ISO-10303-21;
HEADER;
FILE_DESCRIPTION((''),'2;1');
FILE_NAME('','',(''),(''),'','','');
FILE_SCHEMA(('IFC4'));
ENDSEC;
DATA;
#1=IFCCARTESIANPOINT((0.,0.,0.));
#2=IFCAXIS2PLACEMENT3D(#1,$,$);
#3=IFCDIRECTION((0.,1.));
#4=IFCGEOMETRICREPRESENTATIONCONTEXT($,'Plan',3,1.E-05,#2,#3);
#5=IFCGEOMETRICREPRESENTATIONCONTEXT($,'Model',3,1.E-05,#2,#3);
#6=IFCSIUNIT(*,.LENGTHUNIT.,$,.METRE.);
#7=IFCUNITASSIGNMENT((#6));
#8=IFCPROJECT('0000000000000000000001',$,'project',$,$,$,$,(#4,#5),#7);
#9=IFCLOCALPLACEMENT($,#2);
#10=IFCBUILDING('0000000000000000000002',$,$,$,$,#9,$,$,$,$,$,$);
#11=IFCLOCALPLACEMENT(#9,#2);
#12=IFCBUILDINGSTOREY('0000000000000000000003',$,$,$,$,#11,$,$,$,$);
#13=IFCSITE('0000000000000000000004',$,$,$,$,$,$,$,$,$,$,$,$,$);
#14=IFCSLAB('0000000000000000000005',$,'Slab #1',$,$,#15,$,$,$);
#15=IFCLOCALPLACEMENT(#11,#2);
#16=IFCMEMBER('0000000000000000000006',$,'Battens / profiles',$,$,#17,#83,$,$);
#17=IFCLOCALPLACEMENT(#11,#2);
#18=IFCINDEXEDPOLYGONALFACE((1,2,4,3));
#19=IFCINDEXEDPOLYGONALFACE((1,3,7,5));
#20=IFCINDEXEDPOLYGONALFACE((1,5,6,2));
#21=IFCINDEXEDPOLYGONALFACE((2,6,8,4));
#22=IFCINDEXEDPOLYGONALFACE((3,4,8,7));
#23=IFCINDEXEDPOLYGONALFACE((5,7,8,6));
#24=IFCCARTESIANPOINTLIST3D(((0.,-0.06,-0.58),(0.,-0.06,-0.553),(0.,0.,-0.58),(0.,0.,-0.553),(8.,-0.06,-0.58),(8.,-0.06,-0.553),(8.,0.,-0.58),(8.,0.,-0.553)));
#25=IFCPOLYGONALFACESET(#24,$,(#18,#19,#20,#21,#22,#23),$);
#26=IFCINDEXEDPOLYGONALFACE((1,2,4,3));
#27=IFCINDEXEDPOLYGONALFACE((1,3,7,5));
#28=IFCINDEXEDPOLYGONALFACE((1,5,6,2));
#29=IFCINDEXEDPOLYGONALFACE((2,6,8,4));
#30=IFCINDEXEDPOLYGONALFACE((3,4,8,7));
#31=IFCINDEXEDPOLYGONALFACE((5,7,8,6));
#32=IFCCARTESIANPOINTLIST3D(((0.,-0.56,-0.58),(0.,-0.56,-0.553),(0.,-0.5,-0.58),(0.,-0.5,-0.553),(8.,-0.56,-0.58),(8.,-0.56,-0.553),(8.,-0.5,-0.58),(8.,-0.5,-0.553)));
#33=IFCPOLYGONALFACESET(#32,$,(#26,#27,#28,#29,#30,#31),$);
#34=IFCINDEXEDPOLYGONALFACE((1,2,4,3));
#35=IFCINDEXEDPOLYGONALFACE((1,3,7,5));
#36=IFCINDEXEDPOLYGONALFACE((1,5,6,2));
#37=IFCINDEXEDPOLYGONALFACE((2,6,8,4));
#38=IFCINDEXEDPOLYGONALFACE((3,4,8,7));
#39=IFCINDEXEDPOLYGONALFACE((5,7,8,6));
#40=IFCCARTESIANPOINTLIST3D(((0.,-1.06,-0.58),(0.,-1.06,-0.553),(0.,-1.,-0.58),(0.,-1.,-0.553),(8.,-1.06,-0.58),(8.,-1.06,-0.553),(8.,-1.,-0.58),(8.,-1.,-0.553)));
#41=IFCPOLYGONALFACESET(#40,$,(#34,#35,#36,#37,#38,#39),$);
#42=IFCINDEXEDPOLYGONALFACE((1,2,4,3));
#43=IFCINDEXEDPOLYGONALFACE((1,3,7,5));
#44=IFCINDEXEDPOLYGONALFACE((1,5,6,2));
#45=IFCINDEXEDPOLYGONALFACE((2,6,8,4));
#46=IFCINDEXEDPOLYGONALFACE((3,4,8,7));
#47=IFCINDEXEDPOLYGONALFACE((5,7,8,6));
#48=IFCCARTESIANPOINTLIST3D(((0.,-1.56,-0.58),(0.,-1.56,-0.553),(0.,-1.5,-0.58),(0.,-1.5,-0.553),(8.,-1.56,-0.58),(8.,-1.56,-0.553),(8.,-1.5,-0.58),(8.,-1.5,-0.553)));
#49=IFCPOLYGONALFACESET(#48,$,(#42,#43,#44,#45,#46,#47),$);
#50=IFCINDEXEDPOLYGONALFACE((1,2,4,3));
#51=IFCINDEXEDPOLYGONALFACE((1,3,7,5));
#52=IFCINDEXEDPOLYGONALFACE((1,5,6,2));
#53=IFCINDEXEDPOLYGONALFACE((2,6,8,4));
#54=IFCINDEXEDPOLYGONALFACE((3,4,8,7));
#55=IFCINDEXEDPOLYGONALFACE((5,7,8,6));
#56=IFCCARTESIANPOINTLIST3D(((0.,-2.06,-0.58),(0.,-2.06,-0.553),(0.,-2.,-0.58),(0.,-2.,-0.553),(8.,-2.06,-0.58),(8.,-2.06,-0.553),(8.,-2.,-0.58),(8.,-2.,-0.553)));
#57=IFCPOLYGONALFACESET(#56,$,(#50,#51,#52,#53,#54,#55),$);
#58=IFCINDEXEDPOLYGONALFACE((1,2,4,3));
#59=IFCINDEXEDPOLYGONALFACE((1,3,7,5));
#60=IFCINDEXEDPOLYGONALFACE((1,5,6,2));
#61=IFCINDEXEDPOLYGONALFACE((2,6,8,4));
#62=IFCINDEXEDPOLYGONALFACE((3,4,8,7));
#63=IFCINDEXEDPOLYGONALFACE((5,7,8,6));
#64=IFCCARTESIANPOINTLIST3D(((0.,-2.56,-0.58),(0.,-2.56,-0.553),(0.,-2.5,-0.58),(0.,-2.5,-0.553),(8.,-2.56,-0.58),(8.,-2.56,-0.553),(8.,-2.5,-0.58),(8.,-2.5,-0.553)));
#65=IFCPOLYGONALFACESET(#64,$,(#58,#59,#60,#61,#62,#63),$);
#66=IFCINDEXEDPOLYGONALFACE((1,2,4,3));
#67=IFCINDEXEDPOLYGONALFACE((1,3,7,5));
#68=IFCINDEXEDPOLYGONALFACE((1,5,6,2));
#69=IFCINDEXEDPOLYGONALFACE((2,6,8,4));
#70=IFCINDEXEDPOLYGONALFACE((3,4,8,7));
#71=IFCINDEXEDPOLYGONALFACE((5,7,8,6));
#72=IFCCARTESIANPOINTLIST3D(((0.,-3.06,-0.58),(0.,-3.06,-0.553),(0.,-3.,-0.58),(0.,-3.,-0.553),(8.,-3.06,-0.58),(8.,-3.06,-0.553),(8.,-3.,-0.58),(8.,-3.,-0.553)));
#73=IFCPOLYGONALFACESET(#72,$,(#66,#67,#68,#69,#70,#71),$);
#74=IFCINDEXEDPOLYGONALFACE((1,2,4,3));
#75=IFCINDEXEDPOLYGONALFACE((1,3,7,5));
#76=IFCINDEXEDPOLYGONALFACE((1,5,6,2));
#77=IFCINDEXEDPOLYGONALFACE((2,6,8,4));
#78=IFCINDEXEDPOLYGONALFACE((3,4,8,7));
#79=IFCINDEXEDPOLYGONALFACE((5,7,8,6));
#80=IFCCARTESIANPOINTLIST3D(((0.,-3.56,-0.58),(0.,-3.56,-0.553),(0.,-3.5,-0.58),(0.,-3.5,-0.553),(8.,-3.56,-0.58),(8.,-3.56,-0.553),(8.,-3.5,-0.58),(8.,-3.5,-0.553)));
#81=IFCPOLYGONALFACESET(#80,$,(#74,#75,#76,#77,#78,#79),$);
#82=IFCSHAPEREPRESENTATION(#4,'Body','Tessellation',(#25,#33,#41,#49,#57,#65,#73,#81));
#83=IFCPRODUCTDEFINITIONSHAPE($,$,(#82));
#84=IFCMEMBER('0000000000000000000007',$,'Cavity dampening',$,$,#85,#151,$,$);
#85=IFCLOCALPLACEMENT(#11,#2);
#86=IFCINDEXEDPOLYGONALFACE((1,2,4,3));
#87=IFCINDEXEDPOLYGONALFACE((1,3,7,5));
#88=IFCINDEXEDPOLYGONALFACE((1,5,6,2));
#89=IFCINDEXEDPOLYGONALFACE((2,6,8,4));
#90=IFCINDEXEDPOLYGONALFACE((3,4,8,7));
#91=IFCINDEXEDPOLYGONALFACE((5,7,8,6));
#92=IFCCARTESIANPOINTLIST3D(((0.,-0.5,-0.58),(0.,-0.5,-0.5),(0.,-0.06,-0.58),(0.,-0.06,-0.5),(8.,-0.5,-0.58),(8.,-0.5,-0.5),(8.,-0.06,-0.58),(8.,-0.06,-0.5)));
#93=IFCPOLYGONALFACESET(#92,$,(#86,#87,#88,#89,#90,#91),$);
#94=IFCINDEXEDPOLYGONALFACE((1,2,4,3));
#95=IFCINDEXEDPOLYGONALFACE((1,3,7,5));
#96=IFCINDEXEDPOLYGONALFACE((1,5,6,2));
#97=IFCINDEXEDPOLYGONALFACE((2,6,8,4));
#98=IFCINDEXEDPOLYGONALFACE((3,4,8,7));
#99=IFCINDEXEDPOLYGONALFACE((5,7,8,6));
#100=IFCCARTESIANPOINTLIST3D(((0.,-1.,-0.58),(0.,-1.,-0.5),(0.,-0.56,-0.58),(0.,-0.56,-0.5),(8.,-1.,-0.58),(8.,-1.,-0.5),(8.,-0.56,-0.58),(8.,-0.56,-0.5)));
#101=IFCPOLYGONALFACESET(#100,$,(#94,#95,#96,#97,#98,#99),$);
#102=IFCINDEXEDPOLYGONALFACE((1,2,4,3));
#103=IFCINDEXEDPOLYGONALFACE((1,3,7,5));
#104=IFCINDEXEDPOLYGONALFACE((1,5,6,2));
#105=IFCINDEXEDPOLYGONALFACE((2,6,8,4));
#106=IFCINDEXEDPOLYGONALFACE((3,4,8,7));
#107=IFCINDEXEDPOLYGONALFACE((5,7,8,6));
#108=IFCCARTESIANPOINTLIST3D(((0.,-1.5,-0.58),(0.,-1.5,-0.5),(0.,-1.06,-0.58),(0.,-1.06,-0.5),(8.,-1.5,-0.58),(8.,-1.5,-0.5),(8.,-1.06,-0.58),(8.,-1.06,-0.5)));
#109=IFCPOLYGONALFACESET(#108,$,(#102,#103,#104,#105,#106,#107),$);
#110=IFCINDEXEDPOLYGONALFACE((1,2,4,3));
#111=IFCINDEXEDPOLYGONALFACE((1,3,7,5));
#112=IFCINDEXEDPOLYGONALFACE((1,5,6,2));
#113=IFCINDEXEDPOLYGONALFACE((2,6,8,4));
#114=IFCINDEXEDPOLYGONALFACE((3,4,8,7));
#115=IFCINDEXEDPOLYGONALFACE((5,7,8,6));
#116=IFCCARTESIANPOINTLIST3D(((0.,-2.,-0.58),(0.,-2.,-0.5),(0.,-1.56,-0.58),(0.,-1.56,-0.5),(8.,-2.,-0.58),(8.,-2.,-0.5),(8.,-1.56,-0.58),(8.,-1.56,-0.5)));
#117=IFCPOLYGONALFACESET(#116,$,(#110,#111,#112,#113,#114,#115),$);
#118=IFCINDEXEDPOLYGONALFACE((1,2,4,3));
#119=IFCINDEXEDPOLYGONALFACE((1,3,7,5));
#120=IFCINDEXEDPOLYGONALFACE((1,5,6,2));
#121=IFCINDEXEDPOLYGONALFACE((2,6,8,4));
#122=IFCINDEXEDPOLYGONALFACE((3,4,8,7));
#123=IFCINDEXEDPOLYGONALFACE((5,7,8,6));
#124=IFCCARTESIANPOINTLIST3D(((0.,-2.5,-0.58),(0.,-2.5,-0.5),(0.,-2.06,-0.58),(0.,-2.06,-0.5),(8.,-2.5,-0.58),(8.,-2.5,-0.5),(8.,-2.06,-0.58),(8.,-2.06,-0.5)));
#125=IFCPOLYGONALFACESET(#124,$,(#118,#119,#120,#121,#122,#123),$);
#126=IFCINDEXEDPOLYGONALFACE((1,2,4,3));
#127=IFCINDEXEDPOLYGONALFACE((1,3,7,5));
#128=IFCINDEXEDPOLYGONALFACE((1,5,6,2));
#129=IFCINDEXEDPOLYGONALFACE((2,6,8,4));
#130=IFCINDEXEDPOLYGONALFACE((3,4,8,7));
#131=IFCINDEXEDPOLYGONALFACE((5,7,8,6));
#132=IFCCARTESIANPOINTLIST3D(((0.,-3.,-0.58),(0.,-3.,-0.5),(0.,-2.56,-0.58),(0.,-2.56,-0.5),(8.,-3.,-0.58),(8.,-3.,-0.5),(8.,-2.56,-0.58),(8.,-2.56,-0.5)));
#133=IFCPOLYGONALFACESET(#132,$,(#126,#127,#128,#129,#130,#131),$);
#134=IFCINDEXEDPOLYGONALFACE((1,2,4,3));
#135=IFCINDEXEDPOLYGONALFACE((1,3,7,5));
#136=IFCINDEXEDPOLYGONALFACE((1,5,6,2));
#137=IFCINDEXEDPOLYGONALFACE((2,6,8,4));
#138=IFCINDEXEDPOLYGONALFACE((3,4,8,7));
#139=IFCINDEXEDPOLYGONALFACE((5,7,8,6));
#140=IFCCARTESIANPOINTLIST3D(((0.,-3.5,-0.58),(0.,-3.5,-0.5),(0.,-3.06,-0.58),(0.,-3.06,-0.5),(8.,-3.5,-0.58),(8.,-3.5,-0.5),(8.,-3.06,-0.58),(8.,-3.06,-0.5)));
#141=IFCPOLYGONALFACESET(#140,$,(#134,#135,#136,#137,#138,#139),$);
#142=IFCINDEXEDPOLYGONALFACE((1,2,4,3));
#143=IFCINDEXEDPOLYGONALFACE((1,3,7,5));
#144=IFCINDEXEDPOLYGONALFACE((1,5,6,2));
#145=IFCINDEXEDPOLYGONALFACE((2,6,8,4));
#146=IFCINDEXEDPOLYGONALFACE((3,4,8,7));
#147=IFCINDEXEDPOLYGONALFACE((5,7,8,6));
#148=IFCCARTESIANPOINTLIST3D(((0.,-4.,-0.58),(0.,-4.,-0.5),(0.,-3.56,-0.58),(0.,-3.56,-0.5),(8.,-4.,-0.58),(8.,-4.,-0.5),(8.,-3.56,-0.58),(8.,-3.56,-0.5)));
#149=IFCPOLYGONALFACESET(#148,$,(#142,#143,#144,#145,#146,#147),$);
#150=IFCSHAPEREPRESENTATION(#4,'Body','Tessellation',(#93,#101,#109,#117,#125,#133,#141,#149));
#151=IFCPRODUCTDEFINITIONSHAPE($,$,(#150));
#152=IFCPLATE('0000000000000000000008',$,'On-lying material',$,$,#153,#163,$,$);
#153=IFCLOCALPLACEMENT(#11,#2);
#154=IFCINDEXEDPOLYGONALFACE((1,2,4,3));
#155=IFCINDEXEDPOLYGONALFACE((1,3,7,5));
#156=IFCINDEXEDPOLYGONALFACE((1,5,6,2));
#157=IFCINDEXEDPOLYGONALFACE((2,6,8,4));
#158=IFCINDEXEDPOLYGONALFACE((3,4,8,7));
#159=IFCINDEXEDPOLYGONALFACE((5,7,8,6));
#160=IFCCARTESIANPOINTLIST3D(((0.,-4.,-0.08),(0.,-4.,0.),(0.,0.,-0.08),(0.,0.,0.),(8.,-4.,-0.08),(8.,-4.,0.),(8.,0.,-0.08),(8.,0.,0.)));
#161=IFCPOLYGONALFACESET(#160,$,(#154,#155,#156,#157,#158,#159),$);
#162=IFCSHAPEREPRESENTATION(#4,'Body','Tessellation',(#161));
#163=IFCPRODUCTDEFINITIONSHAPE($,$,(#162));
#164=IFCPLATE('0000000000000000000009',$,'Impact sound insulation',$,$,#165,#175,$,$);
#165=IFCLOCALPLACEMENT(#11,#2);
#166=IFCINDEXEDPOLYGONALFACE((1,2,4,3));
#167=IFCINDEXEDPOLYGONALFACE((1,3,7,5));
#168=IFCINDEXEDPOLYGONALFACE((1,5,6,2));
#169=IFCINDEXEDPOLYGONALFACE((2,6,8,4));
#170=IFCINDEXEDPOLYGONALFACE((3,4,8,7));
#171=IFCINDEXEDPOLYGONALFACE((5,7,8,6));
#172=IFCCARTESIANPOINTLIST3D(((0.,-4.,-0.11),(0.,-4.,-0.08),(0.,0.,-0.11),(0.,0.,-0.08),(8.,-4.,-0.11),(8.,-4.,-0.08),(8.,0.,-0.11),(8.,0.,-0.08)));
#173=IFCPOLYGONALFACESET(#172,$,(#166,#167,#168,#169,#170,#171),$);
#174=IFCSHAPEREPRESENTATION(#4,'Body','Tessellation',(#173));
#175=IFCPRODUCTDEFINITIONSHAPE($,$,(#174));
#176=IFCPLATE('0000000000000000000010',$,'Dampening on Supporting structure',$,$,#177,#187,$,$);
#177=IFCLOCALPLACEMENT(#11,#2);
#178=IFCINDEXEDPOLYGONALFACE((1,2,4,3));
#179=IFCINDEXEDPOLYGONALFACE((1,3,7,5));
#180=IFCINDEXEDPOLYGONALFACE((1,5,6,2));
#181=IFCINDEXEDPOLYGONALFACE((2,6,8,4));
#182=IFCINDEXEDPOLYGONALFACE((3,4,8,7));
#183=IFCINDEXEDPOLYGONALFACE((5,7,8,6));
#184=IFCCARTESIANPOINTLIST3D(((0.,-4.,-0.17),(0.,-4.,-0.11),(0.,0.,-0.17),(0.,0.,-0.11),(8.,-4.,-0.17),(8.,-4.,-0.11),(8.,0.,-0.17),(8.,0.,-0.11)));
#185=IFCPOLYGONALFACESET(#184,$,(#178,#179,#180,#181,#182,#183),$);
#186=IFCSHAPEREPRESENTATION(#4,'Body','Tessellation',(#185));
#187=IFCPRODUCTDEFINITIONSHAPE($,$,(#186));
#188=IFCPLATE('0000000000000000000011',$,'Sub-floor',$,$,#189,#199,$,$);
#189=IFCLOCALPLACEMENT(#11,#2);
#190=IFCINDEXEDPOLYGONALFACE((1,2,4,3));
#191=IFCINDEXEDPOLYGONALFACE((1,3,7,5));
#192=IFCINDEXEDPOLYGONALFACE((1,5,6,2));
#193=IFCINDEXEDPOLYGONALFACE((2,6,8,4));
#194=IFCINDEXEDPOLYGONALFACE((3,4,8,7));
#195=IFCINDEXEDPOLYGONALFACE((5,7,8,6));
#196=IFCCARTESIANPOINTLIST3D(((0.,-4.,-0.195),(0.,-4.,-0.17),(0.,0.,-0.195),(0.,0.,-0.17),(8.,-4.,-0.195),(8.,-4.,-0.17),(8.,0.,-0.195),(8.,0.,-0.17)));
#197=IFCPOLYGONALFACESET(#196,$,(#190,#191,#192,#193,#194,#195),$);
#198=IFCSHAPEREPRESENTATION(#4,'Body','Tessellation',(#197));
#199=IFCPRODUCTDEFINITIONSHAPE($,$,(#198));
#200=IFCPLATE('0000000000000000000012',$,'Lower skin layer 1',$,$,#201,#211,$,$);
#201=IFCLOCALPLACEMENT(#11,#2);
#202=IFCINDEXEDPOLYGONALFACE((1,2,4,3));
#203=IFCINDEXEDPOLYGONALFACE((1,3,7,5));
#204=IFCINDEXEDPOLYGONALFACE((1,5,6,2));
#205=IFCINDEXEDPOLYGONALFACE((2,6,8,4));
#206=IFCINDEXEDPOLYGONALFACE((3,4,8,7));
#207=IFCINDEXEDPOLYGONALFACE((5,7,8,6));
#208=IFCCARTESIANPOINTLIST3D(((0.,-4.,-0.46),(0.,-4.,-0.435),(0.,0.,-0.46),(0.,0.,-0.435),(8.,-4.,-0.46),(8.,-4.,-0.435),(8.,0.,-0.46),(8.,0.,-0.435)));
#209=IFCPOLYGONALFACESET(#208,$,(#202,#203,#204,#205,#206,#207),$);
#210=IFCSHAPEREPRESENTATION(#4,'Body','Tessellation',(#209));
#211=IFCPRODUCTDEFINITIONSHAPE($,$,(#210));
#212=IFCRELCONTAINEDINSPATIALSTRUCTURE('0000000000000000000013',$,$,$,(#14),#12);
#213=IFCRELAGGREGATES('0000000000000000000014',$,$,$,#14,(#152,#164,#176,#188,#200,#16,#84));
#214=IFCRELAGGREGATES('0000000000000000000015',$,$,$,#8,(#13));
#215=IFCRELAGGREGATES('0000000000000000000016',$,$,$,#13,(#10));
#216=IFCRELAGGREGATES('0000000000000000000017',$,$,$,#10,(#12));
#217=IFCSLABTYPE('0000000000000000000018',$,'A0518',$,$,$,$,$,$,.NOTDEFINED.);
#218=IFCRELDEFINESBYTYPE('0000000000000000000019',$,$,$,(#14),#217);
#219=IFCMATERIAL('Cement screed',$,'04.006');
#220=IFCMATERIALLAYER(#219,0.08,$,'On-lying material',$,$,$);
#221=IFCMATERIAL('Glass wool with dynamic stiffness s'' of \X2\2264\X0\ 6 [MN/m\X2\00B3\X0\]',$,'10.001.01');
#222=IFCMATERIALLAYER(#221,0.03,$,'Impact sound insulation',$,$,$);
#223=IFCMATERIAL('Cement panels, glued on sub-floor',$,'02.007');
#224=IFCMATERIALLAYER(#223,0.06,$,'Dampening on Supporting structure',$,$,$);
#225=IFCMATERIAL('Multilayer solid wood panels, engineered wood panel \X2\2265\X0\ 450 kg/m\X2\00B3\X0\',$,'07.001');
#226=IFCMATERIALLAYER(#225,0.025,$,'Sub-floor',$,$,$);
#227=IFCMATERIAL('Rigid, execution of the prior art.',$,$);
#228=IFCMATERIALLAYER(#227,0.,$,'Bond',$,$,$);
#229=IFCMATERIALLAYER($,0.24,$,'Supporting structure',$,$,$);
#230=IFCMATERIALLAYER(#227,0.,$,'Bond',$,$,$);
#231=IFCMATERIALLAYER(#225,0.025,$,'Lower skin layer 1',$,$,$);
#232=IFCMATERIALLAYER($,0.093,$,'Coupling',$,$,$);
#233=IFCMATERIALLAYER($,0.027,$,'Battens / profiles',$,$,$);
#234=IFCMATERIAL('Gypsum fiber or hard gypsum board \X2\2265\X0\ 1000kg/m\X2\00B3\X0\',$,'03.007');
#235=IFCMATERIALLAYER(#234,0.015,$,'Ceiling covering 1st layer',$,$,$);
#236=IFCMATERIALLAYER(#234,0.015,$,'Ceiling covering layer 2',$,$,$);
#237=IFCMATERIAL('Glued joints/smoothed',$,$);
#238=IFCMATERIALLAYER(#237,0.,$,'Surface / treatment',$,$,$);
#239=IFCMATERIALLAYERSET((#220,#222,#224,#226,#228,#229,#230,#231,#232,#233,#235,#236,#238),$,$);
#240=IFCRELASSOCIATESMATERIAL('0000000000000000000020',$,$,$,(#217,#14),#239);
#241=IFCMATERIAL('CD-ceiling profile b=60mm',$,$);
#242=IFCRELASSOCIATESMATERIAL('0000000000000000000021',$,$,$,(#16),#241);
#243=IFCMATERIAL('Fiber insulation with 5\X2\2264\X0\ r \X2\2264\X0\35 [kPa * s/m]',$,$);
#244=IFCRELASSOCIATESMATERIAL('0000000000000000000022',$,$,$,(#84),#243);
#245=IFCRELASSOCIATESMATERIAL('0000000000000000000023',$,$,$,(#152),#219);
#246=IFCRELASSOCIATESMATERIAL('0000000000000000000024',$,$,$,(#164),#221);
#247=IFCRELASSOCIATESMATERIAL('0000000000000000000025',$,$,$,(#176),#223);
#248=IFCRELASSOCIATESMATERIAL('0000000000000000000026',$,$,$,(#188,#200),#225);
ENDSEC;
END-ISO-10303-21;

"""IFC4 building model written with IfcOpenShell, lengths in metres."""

from ifc_helpers import new_model, si_unit, direction, frame, frame_2d, origin, origin_with_axes, place, context, project, spatial, rectangle, extrude, material, layer, layer_set, type_object, element, aggregate, save


model = new_model("IFC4")

# Units and contexts
plan_context = context("Plan", 3, precision=1e-05, world=origin(), true_north=direction((0.0, 1.0)))
model_context = context("Model", 3, precision=1e-05, world=origin(), true_north=direction((0.0, 1.0)))
ifc_project = project(units=[si_unit("LENGTHUNIT", "METRE")], contexts=[plan_context, model_context])

# Site, building, storey
site = spatial("IfcSite", under=ifc_project)
building_placement = place(None, origin())
building = spatial("IfcBuilding", under=site, at=building_placement)
storey_placement = place(building_placement, origin())
storey = spatial("IfcBuildingStorey", under=building, at=storey_placement)

# Slab, members, plates
ifc_material_1 = material(Name="Cement screed", Category="04.006")
ifc_layer_1 = layer(ifc_material_1, 0.08, Name="On-lying material")
ifc_material_2 = material(Name="Glass wool with dynamic stiffness s' of ≤ 6 [MN/m³]", Category="10.001.01")
ifc_layer_2 = layer(ifc_material_2, 0.03, Name="Impact sound insulation")
ifc_material_3 = material(Name="Cement panels, glued on sub-floor", Category="02.007")
ifc_layer_3 = layer(ifc_material_3, 0.06, Name="Dampening on Supporting structure")
ifc_material_4 = material(Name="Multilayer solid wood panels, engineered wood panel ≥ 450 kg/m³", Category="07.001")
ifc_layer_4 = layer(ifc_material_4, 0.025, Name="Sub-floor")
ifc_material_5 = material(Name="Rigid, execution of the prior art.")
ifc_layer_5 = layer(ifc_material_5, 0.0, Name="Bond")
ifc_layer_6 = layer(None, 0.24, Name="Supporting structure")
ifc_layer_7 = layer(ifc_material_5, 0.0, Name="Bond")
ifc_layer_8 = layer(ifc_material_4, 0.025, Name="Lower skin layer 1")
ifc_layer_9 = layer(None, 0.093, Name="Coupling")
ifc_layer_10 = layer(None, 0.027, Name="Battens / profiles")
ifc_material_6 = material(Name="Gypsum fiber or hard gypsum board ≥ 1000kg/m³", Category="03.007")
ifc_layer_11 = layer(ifc_material_6, 0.015, Name="Ceiling covering 1st layer")
ifc_layer_12 = layer(ifc_material_6, 0.015, Name="Ceiling covering layer 2")
ifc_material_7 = material(Name="Glued joints/smoothed")
ifc_layer_13 = layer(ifc_material_7, 0.0, Name="Surface / treatment")
ifc_layer_set = layer_set([ifc_layer_1, ifc_layer_2, ifc_layer_3, ifc_layer_4, ifc_layer_5, ifc_layer_6, ifc_layer_7, ifc_layer_8, ifc_layer_9, ifc_layer_10, ifc_layer_11, ifc_layer_12, ifc_layer_13])
slab_type = type_object("IfcSlabType", Name="A0518", PredefinedType="NOTDEFINED", material=ifc_layer_set)
slab_placement = place(None, frame((0.0, 0.0, 0.0), z_axis=(0.0, 0.0, -1.0), x_axis=(1.0, 0.0, 0.0)))
slab = element("IfcSlab", 1, at=slab_placement, inside=storey, type_object=slab_type, material=ifc_layer_set, Name="Slab #1")
ifc_material_8 = material(Name="Fiber insulation with 5≤ r ≤35 [kPa * s/m]")
ifc_material_9 = material(Name="CD-ceiling profile b=60mm")
member_1_placement = place(slab_placement, origin())
member_1 = element("IfcMember", 2, at=member_1_placement, material=ifc_material_9, Name="Battens / profiles", context=plan_context, shape_type="SweptSolid", body=[
    extrude(rectangle(XDim=0.06, YDim=0.027, at=frame_2d((0.03, 0.0135), x_axis=(1.0, 0.0))), frame((0.0, 0.0, 0.553), z_axis=(1.0, 0.0, 0.0), x_axis=(0.0, 1.0, 0.0)), (0.0, 0.0, 1.0), 8.0),
    extrude(rectangle(XDim=0.06, YDim=0.027, at=frame_2d((0.03, 0.0135), x_axis=(1.0, 0.0))), frame((0.0, 0.5, 0.553), z_axis=(1.0, 0.0, 0.0), x_axis=(0.0, 1.0, 0.0)), (0.0, 0.0, 1.0), 8.0),
    extrude(rectangle(XDim=0.06, YDim=0.027, at=frame_2d((0.03, 0.0135), x_axis=(1.0, 0.0))), frame((0.0, 1.0, 0.553), z_axis=(1.0, 0.0, 0.0), x_axis=(0.0, 1.0, 0.0)), (0.0, 0.0, 1.0), 8.0),
    extrude(rectangle(XDim=0.06, YDim=0.027, at=frame_2d((0.03, 0.0135), x_axis=(1.0, 0.0))), frame((0.0, 1.5, 0.553), z_axis=(1.0, 0.0, 0.0), x_axis=(0.0, 1.0, 0.0)), (0.0, 0.0, 1.0), 8.0),
    extrude(rectangle(XDim=0.06, YDim=0.027, at=frame_2d((0.03, 0.0135), x_axis=(1.0, 0.0))), frame((0.0, 2.0, 0.553), z_axis=(1.0, 0.0, 0.0), x_axis=(0.0, 1.0, 0.0)), (0.0, 0.0, 1.0), 8.0),
    extrude(rectangle(XDim=0.06, YDim=0.027, at=frame_2d((0.03, 0.0135), x_axis=(1.0, 0.0))), frame((0.0, 2.5, 0.553), z_axis=(1.0, 0.0, 0.0), x_axis=(0.0, 1.0, 0.0)), (0.0, 0.0, 1.0), 8.0),
    extrude(rectangle(XDim=0.06, YDim=0.027, at=frame_2d((0.03, 0.0135), x_axis=(1.0, 0.0))), frame((0.0, 3.0, 0.553), z_axis=(1.0, 0.0, 0.0), x_axis=(0.0, 1.0, 0.0)), (0.0, 0.0, 1.0), 8.0),
    extrude(rectangle(XDim=0.06, YDim=0.027, at=frame_2d((0.03, 0.0135), x_axis=(1.0, 0.0))), frame((0.0, 3.5, 0.553), z_axis=(1.0, 0.0, 0.0), x_axis=(0.0, 1.0, 0.0)), (0.0, 0.0, 1.0), 8.0),
])
member_2_placement = place(slab_placement, origin())
member_2 = element("IfcMember", 3, at=member_2_placement, material=ifc_material_8, Name="Cavity dampening", context=plan_context, shape_type="SweptSolid", body=[
    extrude(rectangle(XDim=0.44, YDim=0.08, at=frame_2d((0.22, 0.04), x_axis=(1.0, 0.0))), frame((0.0, 0.06, 0.5), z_axis=(1.0, 0.0, 0.0), x_axis=(0.0, 1.0, 0.0)), (0.0, 0.0, 1.0), 8.0),
    extrude(rectangle(XDim=0.44, YDim=0.08, at=frame_2d((0.22, 0.04), x_axis=(1.0, 0.0))), frame((0.0, 0.56, 0.5), z_axis=(1.0, 0.0, 0.0), x_axis=(0.0, 1.0, 0.0)), (0.0, 0.0, 1.0), 8.0),
    extrude(rectangle(XDim=0.44, YDim=0.08, at=frame_2d((0.22, 0.04), x_axis=(1.0, 0.0))), frame((0.0, 1.06, 0.5), z_axis=(1.0, 0.0, 0.0), x_axis=(0.0, 1.0, 0.0)), (0.0, 0.0, 1.0), 8.0),
    extrude(rectangle(XDim=0.44, YDim=0.08, at=frame_2d((0.22, 0.04), x_axis=(1.0, 0.0))), frame((0.0, 1.56, 0.5), z_axis=(1.0, 0.0, 0.0), x_axis=(0.0, 1.0, 0.0)), (0.0, 0.0, 1.0), 8.0),
    extrude(rectangle(XDim=0.44, YDim=0.08, at=frame_2d((0.22, 0.04), x_axis=(1.0, 0.0))), frame((0.0, 2.06, 0.5), z_axis=(1.0, 0.0, 0.0), x_axis=(0.0, 1.0, 0.0)), (0.0, 0.0, 1.0), 8.0),
    extrude(rectangle(XDim=0.44, YDim=0.08, at=frame_2d((0.22, 0.04), x_axis=(1.0, 0.0))), frame((0.0, 2.56, 0.5), z_axis=(1.0, 0.0, 0.0), x_axis=(0.0, 1.0, 0.0)), (0.0, 0.0, 1.0), 8.0),
    extrude(rectangle(XDim=0.44, YDim=0.08, at=frame_2d((0.22, 0.04), x_axis=(1.0, 0.0))), frame((0.0, 3.06, 0.5), z_axis=(1.0, 0.0, 0.0), x_axis=(0.0, 1.0, 0.0)), (0.0, 0.0, 1.0), 8.0),
    extrude(rectangle(XDim=0.44, YDim=0.08, at=frame_2d((0.22, 0.04), x_axis=(1.0, 0.0))), frame((0.0, 3.56, 0.5), z_axis=(1.0, 0.0, 0.0), x_axis=(0.0, 1.0, 0.0)), (0.0, 0.0, 1.0), 8.0),
])
plate_1_placement = place(slab_placement, origin())
plate_1 = element("IfcPlate", 4, at=plate_1_placement, material=ifc_material_1, Name="On-lying material", context=plan_context, shape_type="SweptSolid", body=[
    extrude(rectangle(XDim=8.0, YDim=4.0, at=frame_2d((4.0, 2.0), x_axis=(1.0, 0.0))), origin_with_axes(), (0.0, 0.0, 1.0), 0.08),
])
plate_2_placement = place(slab_placement, origin())
plate_2 = element("IfcPlate", 5, at=plate_2_placement, material=ifc_material_2, Name="Impact sound insulation", context=plan_context, shape_type="SweptSolid", body=[
    extrude(rectangle(XDim=8.0, YDim=4.0, at=frame_2d((4.0, 2.0), x_axis=(1.0, 0.0))), frame((0.0, 0.0, 0.08), z_axis=(0.0, 0.0, 1.0), x_axis=(1.0, 0.0, 0.0)), (0.0, 0.0, 1.0), 0.03),
])
plate_3_placement = place(slab_placement, origin())
plate_3 = element("IfcPlate", 6, at=plate_3_placement, material=ifc_material_3, Name="Dampening on Supporting structure", context=plan_context, shape_type="SweptSolid", body=[
    extrude(rectangle(XDim=8.0, YDim=4.0, at=frame_2d((4.0, 2.0), x_axis=(1.0, 0.0))), frame((0.0, 0.0, 0.11), z_axis=(0.0, 0.0, 1.0), x_axis=(1.0, 0.0, 0.0)), (0.0, 0.0, 1.0), 0.06),
])
plate_4_placement = place(slab_placement, origin())
plate_4 = element("IfcPlate", 7, at=plate_4_placement, material=ifc_material_4, Name="Sub-floor", context=plan_context, shape_type="SweptSolid", body=[
    extrude(rectangle(XDim=8.0, YDim=4.0, at=frame_2d((4.0, 2.0), x_axis=(1.0, 0.0))), frame((0.0, 0.0, 0.17), z_axis=(0.0, 0.0, 1.0), x_axis=(1.0, 0.0, 0.0)), (0.0, 0.0, 1.0), 0.025),
])
plate_5_placement = place(slab_placement, origin())
plate_5 = element("IfcPlate", 8, at=plate_5_placement, material=ifc_material_4, Name="Lower skin layer 1", context=plan_context, shape_type="SweptSolid", body=[
    extrude(rectangle(XDim=8.0, YDim=4.0, at=frame_2d((4.0, 2.0), x_axis=(1.0, 0.0))), frame((0.0, 0.0, 0.435), z_axis=(0.0, 0.0, 1.0), x_axis=(1.0, 0.0, 0.0)), (0.0, 0.0, 1.0), 0.025),
])
aggregate(slab, [plate_1, plate_2, plate_3, plate_4, plate_5, member_1, member_2])

save(model, "model.ifc")
